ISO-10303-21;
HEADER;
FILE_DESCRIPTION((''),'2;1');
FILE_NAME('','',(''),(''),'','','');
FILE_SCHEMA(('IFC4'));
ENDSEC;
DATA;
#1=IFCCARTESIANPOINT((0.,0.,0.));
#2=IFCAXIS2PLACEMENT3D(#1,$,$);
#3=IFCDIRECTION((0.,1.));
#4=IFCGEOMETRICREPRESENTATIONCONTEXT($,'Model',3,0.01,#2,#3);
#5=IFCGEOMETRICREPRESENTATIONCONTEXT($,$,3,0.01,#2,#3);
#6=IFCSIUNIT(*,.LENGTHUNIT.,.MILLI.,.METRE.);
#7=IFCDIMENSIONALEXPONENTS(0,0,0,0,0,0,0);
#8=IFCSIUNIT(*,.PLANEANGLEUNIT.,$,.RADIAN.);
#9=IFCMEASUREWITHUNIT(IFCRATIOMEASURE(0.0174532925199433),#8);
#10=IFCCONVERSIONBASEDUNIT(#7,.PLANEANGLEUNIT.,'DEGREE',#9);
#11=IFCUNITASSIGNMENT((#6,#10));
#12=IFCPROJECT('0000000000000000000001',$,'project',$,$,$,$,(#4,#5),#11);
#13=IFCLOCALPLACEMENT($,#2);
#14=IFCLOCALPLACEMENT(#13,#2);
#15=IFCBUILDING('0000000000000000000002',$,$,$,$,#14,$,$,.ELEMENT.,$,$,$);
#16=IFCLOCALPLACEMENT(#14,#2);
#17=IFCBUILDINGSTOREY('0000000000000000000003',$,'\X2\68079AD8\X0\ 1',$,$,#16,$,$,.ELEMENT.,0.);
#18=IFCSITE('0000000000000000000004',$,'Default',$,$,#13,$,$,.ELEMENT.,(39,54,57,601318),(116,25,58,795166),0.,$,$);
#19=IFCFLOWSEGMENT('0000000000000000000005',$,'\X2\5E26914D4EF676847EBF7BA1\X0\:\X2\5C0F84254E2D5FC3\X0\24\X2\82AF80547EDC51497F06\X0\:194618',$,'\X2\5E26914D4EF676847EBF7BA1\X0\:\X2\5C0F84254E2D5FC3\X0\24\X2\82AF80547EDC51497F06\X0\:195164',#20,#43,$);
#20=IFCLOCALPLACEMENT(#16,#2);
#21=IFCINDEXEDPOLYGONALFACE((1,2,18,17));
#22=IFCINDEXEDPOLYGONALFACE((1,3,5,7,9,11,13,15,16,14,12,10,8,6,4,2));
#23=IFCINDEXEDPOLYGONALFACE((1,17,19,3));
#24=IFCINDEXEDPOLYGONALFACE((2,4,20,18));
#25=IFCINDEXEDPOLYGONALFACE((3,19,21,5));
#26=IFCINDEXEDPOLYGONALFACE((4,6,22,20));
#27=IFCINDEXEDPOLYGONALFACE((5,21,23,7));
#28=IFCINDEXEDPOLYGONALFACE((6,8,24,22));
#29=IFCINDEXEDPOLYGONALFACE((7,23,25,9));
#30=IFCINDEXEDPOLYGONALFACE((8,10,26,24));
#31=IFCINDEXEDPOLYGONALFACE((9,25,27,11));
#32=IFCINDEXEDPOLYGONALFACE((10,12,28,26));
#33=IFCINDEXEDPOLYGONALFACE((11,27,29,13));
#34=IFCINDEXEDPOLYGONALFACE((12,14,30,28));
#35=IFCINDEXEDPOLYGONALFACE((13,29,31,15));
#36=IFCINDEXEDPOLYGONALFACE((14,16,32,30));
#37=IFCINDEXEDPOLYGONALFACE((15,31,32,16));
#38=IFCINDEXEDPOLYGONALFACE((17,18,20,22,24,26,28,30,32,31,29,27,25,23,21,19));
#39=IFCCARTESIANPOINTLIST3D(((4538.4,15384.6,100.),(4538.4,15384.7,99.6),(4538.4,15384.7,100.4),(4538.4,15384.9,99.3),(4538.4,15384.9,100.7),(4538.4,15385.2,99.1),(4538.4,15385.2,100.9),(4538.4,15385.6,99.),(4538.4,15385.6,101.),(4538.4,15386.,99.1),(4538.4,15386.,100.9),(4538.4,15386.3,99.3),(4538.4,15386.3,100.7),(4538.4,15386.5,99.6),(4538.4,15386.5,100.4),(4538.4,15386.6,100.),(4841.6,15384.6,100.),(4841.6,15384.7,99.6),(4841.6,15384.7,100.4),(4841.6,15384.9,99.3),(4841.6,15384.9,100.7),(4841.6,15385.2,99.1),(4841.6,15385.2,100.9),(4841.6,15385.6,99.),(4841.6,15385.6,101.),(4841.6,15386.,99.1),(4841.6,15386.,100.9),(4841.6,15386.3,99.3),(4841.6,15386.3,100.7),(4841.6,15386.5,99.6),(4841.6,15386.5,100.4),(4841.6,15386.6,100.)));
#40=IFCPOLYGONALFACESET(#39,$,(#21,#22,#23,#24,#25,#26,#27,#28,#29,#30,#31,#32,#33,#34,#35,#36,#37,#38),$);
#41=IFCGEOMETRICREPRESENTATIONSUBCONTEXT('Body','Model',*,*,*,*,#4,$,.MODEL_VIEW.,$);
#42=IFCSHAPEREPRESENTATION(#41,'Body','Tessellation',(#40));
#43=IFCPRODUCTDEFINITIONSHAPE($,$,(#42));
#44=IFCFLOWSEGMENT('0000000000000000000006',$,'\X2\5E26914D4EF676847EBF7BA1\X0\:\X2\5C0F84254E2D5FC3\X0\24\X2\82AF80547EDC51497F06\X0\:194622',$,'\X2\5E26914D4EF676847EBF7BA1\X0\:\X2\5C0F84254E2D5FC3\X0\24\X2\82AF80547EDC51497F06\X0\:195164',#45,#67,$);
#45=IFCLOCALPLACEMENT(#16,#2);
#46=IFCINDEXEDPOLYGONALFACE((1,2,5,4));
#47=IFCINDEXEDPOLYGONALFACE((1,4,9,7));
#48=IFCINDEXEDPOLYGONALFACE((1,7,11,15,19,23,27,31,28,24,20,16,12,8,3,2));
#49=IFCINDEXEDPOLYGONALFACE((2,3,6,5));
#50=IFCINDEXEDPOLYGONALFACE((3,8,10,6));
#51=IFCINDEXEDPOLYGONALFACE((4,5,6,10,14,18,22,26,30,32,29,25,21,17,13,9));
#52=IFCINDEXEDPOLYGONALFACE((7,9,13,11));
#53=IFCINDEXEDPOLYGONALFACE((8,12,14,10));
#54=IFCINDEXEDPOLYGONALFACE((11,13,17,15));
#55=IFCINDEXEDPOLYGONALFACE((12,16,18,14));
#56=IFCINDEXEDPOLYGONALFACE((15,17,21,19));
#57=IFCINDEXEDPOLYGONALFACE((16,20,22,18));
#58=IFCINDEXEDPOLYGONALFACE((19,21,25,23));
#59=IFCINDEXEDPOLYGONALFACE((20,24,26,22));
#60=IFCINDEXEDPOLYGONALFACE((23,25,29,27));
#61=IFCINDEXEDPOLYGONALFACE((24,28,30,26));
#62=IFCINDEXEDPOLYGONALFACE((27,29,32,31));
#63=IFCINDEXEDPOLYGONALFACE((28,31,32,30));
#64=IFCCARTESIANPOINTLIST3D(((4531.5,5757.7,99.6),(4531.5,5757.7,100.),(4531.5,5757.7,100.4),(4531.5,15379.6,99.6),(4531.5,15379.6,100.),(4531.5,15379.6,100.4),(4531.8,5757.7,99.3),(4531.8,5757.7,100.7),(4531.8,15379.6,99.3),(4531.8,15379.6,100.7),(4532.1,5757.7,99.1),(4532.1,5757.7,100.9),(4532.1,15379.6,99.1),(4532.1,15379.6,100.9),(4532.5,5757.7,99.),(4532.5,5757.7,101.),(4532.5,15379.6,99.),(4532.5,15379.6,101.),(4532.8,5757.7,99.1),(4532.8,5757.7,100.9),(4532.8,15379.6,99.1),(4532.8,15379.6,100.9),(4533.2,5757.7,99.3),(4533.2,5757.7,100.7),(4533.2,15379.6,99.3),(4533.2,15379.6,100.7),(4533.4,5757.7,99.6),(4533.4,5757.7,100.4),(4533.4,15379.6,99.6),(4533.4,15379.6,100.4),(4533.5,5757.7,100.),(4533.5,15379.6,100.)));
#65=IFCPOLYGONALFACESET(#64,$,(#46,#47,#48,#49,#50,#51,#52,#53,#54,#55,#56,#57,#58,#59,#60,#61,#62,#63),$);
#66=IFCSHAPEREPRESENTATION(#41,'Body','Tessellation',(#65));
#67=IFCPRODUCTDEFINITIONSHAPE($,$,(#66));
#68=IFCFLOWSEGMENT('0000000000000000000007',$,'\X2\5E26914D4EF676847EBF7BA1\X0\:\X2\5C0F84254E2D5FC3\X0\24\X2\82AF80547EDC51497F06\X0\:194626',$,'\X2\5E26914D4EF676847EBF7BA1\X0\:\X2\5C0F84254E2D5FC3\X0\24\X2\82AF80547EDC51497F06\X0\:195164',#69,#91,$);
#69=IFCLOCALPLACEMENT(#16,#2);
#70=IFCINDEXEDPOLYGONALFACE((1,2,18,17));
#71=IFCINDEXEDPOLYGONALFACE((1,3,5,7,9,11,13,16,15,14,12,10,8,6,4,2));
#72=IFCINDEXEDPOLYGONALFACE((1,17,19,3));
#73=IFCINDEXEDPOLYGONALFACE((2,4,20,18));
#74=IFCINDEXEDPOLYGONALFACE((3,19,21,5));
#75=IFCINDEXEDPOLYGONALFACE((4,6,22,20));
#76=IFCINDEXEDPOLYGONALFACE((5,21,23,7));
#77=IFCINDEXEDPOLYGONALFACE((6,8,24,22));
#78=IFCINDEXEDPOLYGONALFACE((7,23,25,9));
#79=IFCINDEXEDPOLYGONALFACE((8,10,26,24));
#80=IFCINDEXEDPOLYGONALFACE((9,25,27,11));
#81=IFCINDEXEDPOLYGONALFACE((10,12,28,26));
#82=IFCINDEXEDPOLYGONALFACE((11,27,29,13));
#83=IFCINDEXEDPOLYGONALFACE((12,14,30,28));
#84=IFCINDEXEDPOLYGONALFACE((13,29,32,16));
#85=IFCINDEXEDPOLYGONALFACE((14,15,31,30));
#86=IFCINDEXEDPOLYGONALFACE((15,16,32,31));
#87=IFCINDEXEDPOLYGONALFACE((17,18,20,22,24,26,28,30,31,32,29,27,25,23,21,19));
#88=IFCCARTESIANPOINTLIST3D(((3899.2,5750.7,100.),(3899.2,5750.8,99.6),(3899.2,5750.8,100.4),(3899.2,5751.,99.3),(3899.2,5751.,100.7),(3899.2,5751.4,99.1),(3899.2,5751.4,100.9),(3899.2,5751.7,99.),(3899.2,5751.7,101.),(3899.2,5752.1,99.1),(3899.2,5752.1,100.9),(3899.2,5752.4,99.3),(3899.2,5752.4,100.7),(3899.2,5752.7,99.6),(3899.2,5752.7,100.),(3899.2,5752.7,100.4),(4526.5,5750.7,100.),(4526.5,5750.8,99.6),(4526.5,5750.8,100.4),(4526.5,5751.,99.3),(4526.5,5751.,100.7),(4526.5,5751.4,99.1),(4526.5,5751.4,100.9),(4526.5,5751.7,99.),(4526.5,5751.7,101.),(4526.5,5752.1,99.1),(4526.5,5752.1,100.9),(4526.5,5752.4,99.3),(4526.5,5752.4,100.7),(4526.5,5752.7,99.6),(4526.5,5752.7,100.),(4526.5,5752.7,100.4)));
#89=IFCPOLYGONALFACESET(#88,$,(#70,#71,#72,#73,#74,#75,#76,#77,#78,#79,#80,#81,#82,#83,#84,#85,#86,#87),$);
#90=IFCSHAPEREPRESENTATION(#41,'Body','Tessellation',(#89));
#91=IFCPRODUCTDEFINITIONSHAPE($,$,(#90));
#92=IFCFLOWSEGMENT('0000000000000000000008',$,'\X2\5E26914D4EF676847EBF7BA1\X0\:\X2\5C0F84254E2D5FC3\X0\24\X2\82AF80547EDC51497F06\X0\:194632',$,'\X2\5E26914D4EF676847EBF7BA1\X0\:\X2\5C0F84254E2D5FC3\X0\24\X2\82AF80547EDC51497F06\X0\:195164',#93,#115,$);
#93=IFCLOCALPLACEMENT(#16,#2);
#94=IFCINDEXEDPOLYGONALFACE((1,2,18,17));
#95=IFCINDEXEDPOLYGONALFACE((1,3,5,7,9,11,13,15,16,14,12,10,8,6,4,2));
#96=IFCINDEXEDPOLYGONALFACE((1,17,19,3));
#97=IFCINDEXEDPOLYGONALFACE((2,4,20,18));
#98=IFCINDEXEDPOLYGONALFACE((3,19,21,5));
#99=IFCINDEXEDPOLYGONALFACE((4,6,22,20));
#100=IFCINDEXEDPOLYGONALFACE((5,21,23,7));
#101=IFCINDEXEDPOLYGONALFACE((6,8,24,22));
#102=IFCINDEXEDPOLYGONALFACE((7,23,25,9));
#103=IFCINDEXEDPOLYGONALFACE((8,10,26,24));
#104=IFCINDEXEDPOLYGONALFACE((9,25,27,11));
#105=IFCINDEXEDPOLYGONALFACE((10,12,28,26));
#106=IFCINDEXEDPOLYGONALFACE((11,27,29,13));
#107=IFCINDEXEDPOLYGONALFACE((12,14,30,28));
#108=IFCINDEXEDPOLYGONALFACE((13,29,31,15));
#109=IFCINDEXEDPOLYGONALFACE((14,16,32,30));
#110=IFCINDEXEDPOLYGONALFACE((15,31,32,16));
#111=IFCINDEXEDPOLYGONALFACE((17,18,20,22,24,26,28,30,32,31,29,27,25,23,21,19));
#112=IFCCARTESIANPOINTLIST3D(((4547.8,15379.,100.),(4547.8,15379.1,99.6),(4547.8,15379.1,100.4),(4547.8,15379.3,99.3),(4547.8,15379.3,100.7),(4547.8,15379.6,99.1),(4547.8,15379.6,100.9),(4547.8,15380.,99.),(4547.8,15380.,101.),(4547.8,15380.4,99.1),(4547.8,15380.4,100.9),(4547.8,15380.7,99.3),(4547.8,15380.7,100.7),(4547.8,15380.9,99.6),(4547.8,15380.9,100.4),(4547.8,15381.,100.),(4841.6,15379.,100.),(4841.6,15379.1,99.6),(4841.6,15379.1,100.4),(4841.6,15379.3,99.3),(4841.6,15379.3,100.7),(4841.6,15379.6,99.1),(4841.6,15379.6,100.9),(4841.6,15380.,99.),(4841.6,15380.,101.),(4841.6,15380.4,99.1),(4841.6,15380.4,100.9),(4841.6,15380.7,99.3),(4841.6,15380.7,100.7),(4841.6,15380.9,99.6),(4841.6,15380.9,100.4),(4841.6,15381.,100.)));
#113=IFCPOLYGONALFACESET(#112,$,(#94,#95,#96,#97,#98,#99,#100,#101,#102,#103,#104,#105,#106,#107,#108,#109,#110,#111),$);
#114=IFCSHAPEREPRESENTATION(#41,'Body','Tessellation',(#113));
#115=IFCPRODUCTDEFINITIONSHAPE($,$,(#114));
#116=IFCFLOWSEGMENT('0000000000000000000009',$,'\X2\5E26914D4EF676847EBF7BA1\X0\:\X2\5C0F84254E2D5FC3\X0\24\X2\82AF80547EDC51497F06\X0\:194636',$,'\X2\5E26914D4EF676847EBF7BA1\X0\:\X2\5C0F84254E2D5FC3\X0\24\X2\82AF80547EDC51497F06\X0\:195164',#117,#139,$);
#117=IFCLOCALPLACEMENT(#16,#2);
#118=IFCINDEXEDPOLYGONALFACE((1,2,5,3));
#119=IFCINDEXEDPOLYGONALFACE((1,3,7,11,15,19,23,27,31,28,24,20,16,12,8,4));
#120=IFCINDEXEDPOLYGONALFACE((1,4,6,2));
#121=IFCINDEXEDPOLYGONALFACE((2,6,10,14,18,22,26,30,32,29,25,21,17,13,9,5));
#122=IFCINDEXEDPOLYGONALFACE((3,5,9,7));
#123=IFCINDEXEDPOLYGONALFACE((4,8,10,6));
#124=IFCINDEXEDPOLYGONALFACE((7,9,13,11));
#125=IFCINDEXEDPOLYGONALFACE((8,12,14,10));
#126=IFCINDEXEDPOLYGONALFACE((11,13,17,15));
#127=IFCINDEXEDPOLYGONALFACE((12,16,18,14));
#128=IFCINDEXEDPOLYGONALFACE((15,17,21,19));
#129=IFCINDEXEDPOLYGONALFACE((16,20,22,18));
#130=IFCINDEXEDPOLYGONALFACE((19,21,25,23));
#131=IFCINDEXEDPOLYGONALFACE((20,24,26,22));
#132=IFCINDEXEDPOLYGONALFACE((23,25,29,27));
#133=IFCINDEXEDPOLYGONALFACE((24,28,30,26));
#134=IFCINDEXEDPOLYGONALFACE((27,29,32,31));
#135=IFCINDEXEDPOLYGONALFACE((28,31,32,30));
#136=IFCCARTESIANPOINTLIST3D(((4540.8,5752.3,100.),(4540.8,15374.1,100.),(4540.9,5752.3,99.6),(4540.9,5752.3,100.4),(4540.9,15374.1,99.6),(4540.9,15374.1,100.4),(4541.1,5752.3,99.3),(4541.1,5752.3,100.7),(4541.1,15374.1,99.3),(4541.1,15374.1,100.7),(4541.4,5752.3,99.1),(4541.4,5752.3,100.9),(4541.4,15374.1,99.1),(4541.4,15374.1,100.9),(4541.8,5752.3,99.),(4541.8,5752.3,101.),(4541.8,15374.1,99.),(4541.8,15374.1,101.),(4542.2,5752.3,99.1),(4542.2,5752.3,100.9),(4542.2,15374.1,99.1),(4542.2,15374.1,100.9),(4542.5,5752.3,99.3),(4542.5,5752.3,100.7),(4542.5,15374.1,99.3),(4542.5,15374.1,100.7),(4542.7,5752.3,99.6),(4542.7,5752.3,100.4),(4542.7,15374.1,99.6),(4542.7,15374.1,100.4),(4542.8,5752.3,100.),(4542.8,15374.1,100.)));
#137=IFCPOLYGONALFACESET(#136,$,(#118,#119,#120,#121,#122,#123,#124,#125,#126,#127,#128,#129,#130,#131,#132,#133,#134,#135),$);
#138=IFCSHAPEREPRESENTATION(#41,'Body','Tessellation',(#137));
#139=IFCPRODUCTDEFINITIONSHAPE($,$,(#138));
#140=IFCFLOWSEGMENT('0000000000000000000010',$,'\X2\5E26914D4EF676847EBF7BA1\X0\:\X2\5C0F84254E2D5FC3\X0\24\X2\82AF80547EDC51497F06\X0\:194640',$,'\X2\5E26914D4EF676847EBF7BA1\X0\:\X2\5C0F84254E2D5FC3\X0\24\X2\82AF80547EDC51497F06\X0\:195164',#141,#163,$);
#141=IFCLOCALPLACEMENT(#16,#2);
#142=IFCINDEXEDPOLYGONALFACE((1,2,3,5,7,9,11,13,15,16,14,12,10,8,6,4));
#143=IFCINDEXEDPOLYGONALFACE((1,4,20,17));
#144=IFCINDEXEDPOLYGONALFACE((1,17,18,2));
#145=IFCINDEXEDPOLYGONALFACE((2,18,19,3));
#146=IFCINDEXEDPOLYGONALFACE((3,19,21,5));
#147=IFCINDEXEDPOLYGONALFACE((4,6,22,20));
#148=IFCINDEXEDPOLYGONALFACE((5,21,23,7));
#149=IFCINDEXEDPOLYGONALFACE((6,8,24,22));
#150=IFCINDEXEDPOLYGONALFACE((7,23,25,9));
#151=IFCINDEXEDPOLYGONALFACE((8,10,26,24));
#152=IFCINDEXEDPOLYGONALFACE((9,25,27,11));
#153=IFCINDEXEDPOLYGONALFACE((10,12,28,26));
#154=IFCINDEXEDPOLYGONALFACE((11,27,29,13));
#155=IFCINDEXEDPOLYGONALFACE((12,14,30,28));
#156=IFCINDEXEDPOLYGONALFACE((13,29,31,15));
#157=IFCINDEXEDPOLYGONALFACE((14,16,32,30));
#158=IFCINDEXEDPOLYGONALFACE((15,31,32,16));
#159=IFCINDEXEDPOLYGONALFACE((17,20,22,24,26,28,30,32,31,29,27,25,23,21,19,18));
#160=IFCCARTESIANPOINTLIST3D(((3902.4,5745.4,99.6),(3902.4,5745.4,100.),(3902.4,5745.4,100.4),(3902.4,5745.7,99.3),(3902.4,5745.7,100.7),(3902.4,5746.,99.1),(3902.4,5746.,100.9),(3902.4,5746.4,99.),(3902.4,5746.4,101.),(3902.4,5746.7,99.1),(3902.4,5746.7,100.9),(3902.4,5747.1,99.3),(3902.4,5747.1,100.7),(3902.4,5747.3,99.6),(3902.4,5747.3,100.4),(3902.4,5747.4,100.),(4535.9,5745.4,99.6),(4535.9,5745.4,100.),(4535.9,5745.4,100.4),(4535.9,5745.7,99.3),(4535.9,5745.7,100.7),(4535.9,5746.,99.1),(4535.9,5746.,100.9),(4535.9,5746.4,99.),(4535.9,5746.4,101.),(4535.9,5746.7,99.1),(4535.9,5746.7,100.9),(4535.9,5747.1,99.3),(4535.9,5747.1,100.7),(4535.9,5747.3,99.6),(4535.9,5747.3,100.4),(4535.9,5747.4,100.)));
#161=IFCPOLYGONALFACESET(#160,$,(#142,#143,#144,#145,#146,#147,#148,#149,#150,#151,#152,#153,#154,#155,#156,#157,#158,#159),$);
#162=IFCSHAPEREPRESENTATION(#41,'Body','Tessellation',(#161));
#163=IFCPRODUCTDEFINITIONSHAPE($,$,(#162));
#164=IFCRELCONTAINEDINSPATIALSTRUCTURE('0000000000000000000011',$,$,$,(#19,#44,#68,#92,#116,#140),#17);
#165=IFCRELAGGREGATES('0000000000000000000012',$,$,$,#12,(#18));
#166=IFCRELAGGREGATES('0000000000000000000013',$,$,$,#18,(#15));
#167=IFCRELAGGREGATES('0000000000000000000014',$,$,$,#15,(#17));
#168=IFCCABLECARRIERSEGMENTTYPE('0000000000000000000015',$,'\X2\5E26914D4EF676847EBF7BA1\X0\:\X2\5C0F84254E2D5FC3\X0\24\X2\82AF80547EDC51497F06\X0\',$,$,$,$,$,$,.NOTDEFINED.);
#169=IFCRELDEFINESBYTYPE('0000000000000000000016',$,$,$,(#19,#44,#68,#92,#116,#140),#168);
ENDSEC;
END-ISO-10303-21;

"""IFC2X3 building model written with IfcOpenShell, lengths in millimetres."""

from ifc_helpers import new_model, entity, si_unit, converted_unit, direction, frame, frame_2d, origin, origin_2d_with_axis, place, context, subcontext, project, spatial, circle, extrude, type_object, element, save


model = new_model("IFC2X3")

# Units and contexts
model_context = context("Model", 3, precision=0.01, world=origin(), true_north=direction((0.0, 1.0)))
context_of_model = context(None, 3, precision=0.01, world=origin(), true_north=direction((0.0, 1.0)))
body_context = subcontext(model_context, "Body", "Model", "MODEL_VIEW")
ifc_project = project(units=[si_unit("LENGTHUNIT", "METRE", prefix="MILLI"), converted_unit("PLANEANGLEUNIT", "DEGREE", entity("IfcRatioMeasure", 0.0174532925199433), si_unit("PLANEANGLEUNIT", "RADIAN"), dimensions=[0, 0, 0, 0, 0, 0, 0])], contexts=[model_context, context_of_model])

# Site, building, storey
site_placement = place(None, origin())
site = spatial("IfcSite", under=ifc_project, at=site_placement, Name="Default", CompositionType="ELEMENT", RefLatitude=(39, 54, 57, 601318), RefLongitude=(116, 25, 58, 795166), RefElevation=0.0)
building_placement = place(site_placement, origin())
building = spatial("IfcBuilding", under=site, at=building_placement, CompositionType="ELEMENT")
storey_placement = place(building_placement, origin())
storey = spatial("IfcBuildingStorey", under=building, at=storey_placement, Name="标高 1", CompositionType="ELEMENT", Elevation=0.0)

# Flow segments
cable_carrier_segment_type = type_object("IfcCableCarrierSegmentType", Name="带配件的线管:小营中心24芯联络光缆", PredefinedType="NOTDEFINED")
flow_segment_1_placement = place(storey_placement, origin())
element("IfcFlowSegment", 1, at=flow_segment_1_placement, inside=storey, type_object=cable_carrier_segment_type, Name="带配件的线管:小营中心24芯联络光缆:194618", ObjectType="带配件的线管:小营中心24芯联络光缆:195164", context=body_context, shape_type="SweptSolid", body=[
    extrude(circle(Radius=1.0, at=frame_2d((0.0, 0.0), x_axis=(1.0, 0.0))), frame((4538.4, 15385.6, 100.0), z_axis=(1.0, 0.0, 0.0), x_axis=(0.0, 1.0, 0.0)), (0.0, 0.0, 1.0), 303.2),
])
flow_segment_2_placement = place(storey_placement, origin())
element("IfcFlowSegment", 2, at=flow_segment_2_placement, inside=storey, type_object=cable_carrier_segment_type, Name="带配件的线管:小营中心24芯联络光缆:194622", ObjectType="带配件的线管:小营中心24芯联络光缆:195164", context=body_context, shape_type="SweptSolid", body=[
    extrude(circle(Radius=1.0, at=frame_2d((0.0, 0.0), x_axis=(1.0, 0.0))), frame((4532.5, 5757.7, 100.0), z_axis=(0.0, 1.0, 0.0), x_axis=(-1.0, 0.0, 0.0)), (0.0, 0.0, 1.0), 9621.9),
])
flow_segment_3_placement = place(storey_placement, origin())
element("IfcFlowSegment", 3, at=flow_segment_3_placement, inside=storey, type_object=cable_carrier_segment_type, Name="带配件的线管:小营中心24芯联络光缆:194626", ObjectType="带配件的线管:小营中心24芯联络光缆:195164", context=body_context, shape_type="SweptSolid", body=[
    extrude(circle(Radius=1.0, at=origin_2d_with_axis()), frame((3899.2, 5751.7, 100.0), z_axis=(1.0, 0.0, 0.0), x_axis=(0.0, -1.0, 0.0)), (0.0, 0.0, 1.0), 627.3),
])
flow_segment_4_placement = place(storey_placement, origin())
element("IfcFlowSegment", 4, at=flow_segment_4_placement, inside=storey, type_object=cable_carrier_segment_type, Name="带配件的线管:小营中心24芯联络光缆:194632", ObjectType="带配件的线管:小营中心24芯联络光缆:195164", context=body_context, shape_type="SweptSolid", body=[
    extrude(circle(Radius=1.0, at=frame_2d((0.0, 0.0), x_axis=(1.0, 0.0))), frame((4547.8, 15380.0, 100.0), z_axis=(1.0, 0.0, 0.0), x_axis=(0.0, 1.0, 0.0)), (0.0, 0.0, 1.0), 293.9),
])
flow_segment_5_placement = place(storey_placement, origin())
element("IfcFlowSegment", 5, at=flow_segment_5_placement, inside=storey, type_object=cable_carrier_segment_type, Name="带配件的线管:小营中心24芯联络光缆:194636", ObjectType="带配件的线管:小营中心24芯联络光缆:195164", context=body_context, shape_type="SweptSolid", body=[
    extrude(circle(Radius=1.0, at=frame_2d((0.0, 0.0), x_axis=(1.0, 0.0))), frame((4541.8, 5752.3, 100.0), z_axis=(0.0, 1.0, 0.0), x_axis=(-1.0, 0.0, 0.0)), (0.0, 0.0, 1.0), 9621.7),
])
flow_segment_6_placement = place(storey_placement, origin())
element("IfcFlowSegment", 6, at=flow_segment_6_placement, inside=storey, type_object=cable_carrier_segment_type, Name="带配件的线管:小营中心24芯联络光缆:194640", ObjectType="带配件的线管:小营中心24芯联络光缆:195164", context=body_context, shape_type="SweptSolid", body=[
    extrude(circle(Radius=1.0, at=origin_2d_with_axis()), frame((3902.4, 5746.4, 100.0), z_axis=(1.0, 0.0, 0.0), x_axis=(0.0, -1.0, 0.0)), (0.0, 0.0, 1.0), 633.5),
])

save(model, "model.ifc")
